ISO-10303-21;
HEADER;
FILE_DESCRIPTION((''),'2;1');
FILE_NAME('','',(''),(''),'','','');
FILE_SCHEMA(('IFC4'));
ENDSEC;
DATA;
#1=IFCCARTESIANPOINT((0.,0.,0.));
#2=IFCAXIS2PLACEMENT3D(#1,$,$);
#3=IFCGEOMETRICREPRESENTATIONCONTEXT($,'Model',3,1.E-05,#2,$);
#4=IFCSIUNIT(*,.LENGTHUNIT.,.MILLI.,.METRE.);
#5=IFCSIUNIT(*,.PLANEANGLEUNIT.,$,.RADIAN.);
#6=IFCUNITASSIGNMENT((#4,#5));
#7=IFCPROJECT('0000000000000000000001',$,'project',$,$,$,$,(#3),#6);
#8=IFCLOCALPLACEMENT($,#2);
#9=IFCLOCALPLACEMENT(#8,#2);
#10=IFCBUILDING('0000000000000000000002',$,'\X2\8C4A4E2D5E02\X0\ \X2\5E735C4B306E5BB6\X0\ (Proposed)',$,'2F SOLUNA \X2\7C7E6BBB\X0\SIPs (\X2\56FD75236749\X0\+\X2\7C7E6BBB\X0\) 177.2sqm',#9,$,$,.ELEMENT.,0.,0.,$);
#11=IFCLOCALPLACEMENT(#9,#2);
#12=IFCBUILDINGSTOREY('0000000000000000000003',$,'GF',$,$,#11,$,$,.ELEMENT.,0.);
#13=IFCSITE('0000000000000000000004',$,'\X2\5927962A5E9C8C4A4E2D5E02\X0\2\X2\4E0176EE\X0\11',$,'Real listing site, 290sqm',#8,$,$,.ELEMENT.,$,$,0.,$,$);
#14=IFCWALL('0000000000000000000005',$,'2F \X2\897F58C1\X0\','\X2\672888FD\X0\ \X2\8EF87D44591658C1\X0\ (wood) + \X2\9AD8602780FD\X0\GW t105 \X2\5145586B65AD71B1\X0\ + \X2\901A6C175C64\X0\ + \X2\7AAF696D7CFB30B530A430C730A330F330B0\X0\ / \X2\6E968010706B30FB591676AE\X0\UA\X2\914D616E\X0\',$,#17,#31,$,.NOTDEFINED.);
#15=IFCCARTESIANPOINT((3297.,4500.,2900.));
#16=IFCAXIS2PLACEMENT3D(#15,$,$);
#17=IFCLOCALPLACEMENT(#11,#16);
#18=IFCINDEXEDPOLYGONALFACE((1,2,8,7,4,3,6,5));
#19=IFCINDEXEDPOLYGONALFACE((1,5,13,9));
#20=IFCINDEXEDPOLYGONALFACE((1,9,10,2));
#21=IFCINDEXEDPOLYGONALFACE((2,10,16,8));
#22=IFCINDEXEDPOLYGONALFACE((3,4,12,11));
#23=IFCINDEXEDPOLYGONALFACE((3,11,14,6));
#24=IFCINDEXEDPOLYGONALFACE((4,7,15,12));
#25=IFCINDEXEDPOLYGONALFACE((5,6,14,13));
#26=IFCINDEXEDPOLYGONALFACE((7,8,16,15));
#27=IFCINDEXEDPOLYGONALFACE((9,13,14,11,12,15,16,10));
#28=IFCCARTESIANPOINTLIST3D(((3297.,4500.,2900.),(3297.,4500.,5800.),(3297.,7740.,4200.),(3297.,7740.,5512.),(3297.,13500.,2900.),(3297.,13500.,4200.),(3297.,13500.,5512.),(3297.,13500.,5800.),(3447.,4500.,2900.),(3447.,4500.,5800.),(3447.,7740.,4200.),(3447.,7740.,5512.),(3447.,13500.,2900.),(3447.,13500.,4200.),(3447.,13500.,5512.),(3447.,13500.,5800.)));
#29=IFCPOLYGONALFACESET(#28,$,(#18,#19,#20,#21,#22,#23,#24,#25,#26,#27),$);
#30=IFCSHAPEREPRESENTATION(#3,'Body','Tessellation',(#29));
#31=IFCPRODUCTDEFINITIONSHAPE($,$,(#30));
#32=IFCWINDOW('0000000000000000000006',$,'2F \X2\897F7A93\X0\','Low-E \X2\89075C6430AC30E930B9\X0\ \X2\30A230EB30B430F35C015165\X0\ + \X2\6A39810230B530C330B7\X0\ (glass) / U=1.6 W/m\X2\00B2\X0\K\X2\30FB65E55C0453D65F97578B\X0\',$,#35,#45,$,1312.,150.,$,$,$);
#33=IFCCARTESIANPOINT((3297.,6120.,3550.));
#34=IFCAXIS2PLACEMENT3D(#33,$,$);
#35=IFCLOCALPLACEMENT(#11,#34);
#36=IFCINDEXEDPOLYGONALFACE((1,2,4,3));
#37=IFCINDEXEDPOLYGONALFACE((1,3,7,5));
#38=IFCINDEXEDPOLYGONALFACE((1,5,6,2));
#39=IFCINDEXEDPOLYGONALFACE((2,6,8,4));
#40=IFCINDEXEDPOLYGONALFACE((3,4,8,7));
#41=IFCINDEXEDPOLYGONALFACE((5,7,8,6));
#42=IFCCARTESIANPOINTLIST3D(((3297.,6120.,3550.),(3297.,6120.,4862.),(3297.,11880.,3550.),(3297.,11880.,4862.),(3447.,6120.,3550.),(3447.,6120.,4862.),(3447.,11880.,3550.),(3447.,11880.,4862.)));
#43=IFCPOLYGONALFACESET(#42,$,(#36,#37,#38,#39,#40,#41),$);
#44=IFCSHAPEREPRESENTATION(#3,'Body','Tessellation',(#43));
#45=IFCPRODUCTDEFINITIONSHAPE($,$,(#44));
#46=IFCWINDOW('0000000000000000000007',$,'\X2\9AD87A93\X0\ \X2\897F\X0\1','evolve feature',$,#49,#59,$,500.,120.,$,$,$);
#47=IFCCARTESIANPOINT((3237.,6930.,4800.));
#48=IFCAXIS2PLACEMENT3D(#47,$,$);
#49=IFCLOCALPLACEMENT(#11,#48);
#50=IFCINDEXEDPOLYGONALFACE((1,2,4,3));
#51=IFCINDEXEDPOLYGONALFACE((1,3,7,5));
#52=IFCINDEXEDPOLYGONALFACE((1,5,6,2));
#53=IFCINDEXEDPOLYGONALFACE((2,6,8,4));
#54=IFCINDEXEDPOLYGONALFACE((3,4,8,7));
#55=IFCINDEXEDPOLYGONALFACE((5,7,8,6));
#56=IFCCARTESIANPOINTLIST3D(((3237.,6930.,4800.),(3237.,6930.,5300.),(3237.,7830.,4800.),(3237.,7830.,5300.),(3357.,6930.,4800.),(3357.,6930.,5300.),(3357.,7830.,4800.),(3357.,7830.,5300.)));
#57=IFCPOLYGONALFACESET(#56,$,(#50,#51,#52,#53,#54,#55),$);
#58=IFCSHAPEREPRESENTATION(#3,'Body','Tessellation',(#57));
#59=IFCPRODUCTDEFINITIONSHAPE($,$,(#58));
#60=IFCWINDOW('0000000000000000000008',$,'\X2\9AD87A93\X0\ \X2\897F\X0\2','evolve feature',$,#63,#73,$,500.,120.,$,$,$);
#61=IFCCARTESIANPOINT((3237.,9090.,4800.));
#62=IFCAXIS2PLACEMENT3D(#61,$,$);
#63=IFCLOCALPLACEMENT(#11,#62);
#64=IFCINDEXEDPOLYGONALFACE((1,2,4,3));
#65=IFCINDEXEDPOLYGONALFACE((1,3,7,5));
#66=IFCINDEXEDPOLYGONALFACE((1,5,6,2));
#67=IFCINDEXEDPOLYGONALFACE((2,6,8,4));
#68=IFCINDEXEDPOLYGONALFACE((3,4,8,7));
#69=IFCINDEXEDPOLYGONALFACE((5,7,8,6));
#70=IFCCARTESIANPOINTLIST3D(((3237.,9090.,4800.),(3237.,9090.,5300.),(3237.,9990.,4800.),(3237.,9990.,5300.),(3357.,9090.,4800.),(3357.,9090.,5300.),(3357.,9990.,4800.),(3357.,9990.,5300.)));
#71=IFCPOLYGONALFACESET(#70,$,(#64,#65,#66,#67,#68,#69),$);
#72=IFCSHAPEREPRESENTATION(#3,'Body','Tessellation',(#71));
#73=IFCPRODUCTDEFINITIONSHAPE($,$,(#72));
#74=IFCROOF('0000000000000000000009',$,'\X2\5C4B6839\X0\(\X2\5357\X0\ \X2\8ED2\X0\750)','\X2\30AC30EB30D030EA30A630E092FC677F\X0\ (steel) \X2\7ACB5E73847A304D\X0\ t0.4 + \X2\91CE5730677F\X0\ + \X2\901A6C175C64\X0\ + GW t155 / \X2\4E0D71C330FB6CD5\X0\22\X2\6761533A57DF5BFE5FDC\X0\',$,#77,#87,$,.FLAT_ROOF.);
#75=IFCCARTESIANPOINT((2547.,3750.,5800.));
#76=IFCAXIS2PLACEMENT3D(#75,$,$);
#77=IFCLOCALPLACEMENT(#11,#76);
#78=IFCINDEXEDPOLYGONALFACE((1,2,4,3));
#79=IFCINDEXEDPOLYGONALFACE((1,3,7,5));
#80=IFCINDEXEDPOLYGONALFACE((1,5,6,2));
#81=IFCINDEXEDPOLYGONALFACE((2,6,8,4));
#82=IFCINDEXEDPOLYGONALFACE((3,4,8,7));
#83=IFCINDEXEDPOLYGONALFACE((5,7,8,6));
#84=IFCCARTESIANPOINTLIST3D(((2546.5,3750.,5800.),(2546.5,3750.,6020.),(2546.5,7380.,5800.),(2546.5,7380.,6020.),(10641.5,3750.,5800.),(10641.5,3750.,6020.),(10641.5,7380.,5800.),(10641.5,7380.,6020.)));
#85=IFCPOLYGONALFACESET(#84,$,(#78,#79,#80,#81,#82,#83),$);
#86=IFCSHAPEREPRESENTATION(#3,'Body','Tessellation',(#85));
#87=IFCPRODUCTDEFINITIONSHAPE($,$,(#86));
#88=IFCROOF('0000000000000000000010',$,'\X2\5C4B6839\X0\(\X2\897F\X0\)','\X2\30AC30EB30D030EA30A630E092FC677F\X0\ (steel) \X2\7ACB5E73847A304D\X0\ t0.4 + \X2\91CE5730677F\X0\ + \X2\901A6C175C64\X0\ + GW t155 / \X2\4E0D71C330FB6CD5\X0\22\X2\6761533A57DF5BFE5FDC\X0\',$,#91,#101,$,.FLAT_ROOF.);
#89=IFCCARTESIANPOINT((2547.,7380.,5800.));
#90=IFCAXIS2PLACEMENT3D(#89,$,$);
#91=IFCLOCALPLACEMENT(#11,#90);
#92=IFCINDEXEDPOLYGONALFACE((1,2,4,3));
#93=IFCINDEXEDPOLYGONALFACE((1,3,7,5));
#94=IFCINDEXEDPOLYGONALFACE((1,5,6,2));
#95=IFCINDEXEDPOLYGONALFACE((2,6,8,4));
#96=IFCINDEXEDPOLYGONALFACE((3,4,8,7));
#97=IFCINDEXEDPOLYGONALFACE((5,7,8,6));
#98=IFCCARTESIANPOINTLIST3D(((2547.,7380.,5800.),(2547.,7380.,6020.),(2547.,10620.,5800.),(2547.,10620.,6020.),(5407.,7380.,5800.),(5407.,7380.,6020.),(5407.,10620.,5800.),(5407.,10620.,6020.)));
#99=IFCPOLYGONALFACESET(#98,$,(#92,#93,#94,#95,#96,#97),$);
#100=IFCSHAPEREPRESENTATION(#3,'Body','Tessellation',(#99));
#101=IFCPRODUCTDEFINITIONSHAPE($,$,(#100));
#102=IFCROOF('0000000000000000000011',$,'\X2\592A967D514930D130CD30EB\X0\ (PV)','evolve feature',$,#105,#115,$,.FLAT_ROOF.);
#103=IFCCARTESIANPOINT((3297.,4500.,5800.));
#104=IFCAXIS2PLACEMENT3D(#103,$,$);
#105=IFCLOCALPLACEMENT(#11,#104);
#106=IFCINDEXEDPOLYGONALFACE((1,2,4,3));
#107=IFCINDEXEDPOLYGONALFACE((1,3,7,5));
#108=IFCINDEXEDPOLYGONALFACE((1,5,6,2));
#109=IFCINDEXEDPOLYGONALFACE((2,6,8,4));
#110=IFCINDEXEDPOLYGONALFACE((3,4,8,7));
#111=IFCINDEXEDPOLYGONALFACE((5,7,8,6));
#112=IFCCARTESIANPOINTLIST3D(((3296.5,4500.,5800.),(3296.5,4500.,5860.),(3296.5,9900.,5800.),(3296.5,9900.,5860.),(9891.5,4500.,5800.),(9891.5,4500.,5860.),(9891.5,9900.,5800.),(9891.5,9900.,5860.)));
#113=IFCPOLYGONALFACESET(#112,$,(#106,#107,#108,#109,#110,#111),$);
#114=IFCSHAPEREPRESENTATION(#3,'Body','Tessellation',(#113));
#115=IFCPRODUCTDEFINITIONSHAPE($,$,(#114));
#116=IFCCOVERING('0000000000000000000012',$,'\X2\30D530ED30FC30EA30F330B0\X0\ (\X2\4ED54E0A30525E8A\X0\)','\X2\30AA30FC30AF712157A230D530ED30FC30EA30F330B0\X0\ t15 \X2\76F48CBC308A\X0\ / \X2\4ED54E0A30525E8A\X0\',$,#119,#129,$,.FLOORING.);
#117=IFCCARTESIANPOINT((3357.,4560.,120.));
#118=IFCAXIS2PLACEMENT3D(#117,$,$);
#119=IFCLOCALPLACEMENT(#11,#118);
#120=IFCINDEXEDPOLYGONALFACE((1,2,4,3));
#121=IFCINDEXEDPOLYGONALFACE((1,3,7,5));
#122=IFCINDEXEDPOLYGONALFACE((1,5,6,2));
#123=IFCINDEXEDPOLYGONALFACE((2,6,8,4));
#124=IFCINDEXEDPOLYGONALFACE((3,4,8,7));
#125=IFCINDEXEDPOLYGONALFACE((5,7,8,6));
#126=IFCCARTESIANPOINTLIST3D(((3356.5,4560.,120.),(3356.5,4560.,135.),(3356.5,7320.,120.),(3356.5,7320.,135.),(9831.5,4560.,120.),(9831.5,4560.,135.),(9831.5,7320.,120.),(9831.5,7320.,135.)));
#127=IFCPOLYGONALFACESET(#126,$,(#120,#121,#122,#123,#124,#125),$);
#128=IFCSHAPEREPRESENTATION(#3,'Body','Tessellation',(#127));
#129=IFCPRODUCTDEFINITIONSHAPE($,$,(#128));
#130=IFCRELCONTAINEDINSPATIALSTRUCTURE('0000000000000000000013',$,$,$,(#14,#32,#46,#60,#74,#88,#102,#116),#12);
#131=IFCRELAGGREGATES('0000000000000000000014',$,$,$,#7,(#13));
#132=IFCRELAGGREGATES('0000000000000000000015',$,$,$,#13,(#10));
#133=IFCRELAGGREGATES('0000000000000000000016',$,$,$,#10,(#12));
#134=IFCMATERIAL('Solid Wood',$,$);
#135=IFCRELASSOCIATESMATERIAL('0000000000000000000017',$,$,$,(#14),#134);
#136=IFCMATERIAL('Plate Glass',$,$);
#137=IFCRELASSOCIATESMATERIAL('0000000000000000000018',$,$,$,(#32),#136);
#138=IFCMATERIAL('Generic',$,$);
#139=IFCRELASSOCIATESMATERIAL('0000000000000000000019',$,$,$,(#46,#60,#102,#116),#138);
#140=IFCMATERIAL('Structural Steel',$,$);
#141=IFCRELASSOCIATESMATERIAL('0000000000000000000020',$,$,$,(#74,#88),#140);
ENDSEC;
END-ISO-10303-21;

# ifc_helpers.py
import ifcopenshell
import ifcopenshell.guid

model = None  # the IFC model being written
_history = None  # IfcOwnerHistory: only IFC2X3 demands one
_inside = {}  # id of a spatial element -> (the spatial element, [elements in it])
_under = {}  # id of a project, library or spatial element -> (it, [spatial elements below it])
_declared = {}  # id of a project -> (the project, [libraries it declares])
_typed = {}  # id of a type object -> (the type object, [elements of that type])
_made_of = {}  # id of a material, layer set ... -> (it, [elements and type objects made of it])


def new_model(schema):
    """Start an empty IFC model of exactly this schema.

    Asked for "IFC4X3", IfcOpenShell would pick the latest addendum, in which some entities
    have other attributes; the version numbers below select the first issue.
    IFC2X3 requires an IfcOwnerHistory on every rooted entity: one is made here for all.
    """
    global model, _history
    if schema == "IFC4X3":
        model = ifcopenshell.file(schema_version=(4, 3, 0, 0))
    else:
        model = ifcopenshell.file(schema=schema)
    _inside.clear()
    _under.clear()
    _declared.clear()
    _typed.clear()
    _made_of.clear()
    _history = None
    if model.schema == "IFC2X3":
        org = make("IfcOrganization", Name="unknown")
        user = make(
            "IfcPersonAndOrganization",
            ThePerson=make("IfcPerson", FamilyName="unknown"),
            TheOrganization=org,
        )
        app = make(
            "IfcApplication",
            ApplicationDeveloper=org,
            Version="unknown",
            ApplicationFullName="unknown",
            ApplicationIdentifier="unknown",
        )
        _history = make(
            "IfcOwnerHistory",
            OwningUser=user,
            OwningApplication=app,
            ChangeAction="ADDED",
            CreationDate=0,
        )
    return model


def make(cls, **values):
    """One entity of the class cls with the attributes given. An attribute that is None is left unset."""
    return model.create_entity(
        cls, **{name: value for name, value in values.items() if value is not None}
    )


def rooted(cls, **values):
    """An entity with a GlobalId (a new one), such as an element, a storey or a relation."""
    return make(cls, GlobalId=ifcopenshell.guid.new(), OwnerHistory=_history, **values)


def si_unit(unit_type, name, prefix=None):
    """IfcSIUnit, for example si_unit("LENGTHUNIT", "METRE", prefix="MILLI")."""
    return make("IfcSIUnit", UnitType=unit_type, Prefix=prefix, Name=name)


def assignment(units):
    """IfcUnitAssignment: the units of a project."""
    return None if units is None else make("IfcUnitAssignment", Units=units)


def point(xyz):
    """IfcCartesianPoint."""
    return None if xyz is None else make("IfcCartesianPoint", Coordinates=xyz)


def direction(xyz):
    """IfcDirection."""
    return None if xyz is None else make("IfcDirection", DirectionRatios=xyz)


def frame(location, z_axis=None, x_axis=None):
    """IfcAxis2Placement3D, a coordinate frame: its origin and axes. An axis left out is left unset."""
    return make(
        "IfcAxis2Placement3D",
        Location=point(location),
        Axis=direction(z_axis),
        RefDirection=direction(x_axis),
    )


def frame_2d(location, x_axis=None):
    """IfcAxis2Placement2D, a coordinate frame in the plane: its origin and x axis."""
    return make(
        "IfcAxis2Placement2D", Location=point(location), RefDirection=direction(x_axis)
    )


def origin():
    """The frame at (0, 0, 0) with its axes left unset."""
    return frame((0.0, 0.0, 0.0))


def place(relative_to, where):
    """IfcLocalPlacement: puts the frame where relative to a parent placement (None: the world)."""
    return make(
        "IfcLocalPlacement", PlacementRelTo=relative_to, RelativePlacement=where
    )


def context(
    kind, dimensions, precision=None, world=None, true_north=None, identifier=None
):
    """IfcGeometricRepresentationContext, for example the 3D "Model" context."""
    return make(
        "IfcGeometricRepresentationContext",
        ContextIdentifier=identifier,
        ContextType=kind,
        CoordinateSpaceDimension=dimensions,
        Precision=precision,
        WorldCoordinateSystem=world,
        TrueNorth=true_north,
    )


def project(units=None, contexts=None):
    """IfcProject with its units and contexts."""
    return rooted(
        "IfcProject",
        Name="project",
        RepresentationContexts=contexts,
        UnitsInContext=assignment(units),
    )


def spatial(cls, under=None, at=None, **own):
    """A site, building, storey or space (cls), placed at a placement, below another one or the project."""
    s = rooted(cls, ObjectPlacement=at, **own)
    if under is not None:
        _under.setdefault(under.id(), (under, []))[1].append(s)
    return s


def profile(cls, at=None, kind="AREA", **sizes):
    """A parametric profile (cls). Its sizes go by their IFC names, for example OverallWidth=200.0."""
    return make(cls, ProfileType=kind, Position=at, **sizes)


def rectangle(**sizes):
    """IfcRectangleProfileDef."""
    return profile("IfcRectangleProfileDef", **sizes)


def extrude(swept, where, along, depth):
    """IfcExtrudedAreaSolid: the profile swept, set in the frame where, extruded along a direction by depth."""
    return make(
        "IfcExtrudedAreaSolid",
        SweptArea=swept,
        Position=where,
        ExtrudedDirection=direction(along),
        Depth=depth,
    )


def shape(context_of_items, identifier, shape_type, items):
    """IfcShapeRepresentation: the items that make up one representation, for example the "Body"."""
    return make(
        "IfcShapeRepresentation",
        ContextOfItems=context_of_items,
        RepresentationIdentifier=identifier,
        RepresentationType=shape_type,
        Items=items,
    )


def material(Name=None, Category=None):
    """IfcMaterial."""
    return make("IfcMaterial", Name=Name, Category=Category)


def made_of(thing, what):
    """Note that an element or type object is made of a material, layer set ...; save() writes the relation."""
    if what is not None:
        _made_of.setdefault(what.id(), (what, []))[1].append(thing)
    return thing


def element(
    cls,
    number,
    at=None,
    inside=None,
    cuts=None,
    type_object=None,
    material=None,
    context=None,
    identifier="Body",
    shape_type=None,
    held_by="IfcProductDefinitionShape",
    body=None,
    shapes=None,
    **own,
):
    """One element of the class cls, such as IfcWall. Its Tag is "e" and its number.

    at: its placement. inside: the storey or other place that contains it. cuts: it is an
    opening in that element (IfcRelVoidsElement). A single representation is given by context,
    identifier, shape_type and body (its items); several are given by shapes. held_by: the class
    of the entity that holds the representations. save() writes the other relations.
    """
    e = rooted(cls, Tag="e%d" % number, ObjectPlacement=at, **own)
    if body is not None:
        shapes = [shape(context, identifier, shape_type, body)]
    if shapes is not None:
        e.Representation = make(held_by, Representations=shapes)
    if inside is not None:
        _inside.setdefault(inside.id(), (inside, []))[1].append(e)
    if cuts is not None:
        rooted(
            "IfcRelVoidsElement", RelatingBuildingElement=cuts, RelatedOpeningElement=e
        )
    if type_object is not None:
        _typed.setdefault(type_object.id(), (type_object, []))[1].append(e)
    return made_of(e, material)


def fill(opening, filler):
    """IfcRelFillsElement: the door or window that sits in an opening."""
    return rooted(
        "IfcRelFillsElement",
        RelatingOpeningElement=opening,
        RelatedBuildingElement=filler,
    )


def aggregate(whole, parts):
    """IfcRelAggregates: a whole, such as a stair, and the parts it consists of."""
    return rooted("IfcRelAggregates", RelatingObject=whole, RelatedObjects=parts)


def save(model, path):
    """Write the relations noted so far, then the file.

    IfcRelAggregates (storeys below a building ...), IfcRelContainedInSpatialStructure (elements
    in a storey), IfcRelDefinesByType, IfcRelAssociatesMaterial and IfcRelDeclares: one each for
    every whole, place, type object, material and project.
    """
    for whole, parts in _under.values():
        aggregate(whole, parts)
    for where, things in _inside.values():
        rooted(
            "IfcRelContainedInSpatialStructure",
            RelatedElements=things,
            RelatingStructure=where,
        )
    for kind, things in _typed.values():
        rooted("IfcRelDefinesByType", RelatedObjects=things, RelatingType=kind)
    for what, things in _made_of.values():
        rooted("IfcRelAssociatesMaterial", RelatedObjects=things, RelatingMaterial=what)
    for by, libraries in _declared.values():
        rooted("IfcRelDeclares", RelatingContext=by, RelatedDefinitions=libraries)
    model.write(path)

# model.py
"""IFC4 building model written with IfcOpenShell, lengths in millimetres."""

from ifc_helpers import new_model, si_unit, frame, frame_2d, origin, place, context, project, spatial, rectangle, extrude, material, element, fill, save


model = new_model("IFC4")

# Units and contexts
model_context = context("Model", 3, precision=1e-05, world=origin())
ifc_project = project(units=[si_unit("LENGTHUNIT", "METRE", prefix="MILLI"), si_unit("PLANEANGLEUNIT", "RADIAN")], contexts=[model_context])

# Site, building, storey
site_placement = place(None, origin())
site = spatial("IfcSite", under=ifc_project, at=site_placement, Name="大阪府豊中市2丁目11", ObjectType="Real listing site, 290sqm", CompositionType="ELEMENT", RefElevation=0.0)
building_placement = place(site_placement, origin())
building = spatial("IfcBuilding", under=site, at=building_placement, Name="豊中市 平屋の家 (Proposed)", ObjectType="2F SOLUNA 籾殻SIPs (国産杉+籾殻) 177.2sqm", CompositionType="ELEMENT", ElevationOfRefHeight=0.0, ElevationOfTerrain=0.0)
storey_placement = place(building_placement, origin())
storey = spatial("IfcBuildingStorey", under=building, at=storey_placement, Name="GF", CompositionType="ELEMENT", Elevation=0.0)

# Shared definitions
ifc_material_1 = material(Name="Solid Wood")
ifc_material_2 = material(Name="Generic")

# Shared definitions
ifc_material_3 = material(Name="Plate Glass")

# Wall, openings, windows
wall_1_placement = place(storey_placement, frame((3297.0, 4500.0, 2900.0)))
wall_1 = element("IfcWall", 1, at=wall_1_placement, inside=storey, material=ifc_material_1, Name="2F 西壁", Description="木製 軸組外壁 (wood) + 高性能GW t105 充填断熱 + 通気層 + 窯業系サイディング / 準耐火・外皮UA配慮", PredefinedType="NOTDEFINED", context=model_context, shape_type="SweptSolid", body=[
    extrude(rectangle(XDim=150.0, YDim=9000.0, at=frame_2d((75.0, 4500.0))), frame((3297.0, 4500.0, 2900.0)), (0.0, 0.0, 1.0), 2900.0),
])
opening_1_placement = place(storey_placement, frame((3297.0, 6120.0, 3550.0)))
opening_1 = element("IfcOpeningElement", 2, at=opening_1_placement, cuts=wall_1, PredefinedType="NOTDEFINED", context=model_context, shape_type="SweptSolid", body=[
    extrude(rectangle(XDim=150.0, YDim=5760.0, at=frame_2d((75.0, 2880.0))), frame((3297.0, 6120.0, 3550.0)), (0.0, 0.0, 1.0), 1312.0),
])
opening_2_placement = place(storey_placement, frame((3237.0, 6930.0, 4800.0)))
opening_2 = element("IfcOpeningElement", 3, at=opening_2_placement, cuts=wall_1, PredefinedType="NOTDEFINED", context=model_context, shape_type="SweptSolid", body=[
    extrude(rectangle(XDim=120.0, YDim=900.0, at=frame_2d((60.0, 450.0))), frame((3237.0, 6930.0, 4800.0)), (0.0, 0.0, 1.0), 500.0),
])
opening_3_placement = place(storey_placement, frame((3237.0, 9090.0, 4800.0)))
opening_3 = element("IfcOpeningElement", 4, at=opening_3_placement, cuts=wall_1, PredefinedType="NOTDEFINED", context=model_context, shape_type="SweptSolid", body=[
    extrude(rectangle(XDim=120.0, YDim=900.0, at=frame_2d((60.0, 450.0))), frame((3237.0, 9090.0, 4800.0)), (0.0, 0.0, 1.0), 500.0),
])
window_1_placement = place(storey_placement, frame((3297.0, 6120.0, 3550.0)))
window_1 = element("IfcWindow", 5, at=window_1_placement, inside=storey, material=ifc_material_3, Name="2F 西窓", Description="Low-E 複層ガラス アルゴン封入 + 樹脂サッシ (glass) / U=1.6 W/m²K・日射取得型", OverallHeight=1312.0, OverallWidth=150.0, context=model_context, shape_type="SweptSolid", body=[
    extrude(rectangle(XDim=150.0, YDim=5760.0, at=frame_2d((75.0, 2880.0))), frame((3297.0, 6120.0, 3550.0)), (0.0, 0.0, 1.0), 1312.0),
])
fill(opening_1, window_1)
window_2_placement = place(storey_placement, frame((3237.0, 6930.0, 4800.0)))
window_2 = element("IfcWindow", 6, at=window_2_placement, inside=storey, material=ifc_material_2, Name="高窓 西1", Description="evolve feature", OverallHeight=500.0, OverallWidth=120.0, context=model_context, shape_type="SweptSolid", body=[
    extrude(rectangle(XDim=120.0, YDim=900.0, at=frame_2d((60.0, 450.0))), frame((3237.0, 6930.0, 4800.0)), (0.0, 0.0, 1.0), 500.0),
])
fill(opening_2, window_2)
window_3_placement = place(storey_placement, frame((3237.0, 9090.0, 4800.0)))
window_3 = element("IfcWindow", 7, at=window_3_placement, inside=storey, material=ifc_material_2, Name="高窓 西2", Description="evolve feature", OverallHeight=500.0, OverallWidth=120.0, context=model_context, shape_type="SweptSolid", body=[
    extrude(rectangle(XDim=120.0, YDim=900.0, at=frame_2d((60.0, 450.0))), frame((3237.0, 9090.0, 4800.0)), (0.0, 0.0, 1.0), 500.0),
])
fill(opening_3, window_3)

# Roofs
ifc_material_4 = material(Name="Structural Steel")
roof_1_placement = place(storey_placement, frame((2547.0, 3750.0, 5800.0)))
element("IfcRoof", 8, at=roof_1_placement, inside=storey, material=ifc_material_4, Name="屋根(南 軒750)", Description="ガルバリウム鋼板 (steel) 立平葺き t0.4 + 野地板 + 通気層 + GW t155 / 不燃・法22条区域対応", PredefinedType="FLAT_ROOF", context=model_context, shape_type="SweptSolid", body=[
    extrude(rectangle(XDim=8095.0, YDim=3630.0, at=frame_2d((4047.0, 1815.0))), frame((2547.0, 3750.0, 5800.0)), (0.0, 0.0, 1.0), 220.0),
])
roof_2_placement = place(storey_placement, frame((2547.0, 7380.0, 5800.0)))
element("IfcRoof", 9, at=roof_2_placement, inside=storey, material=ifc_material_4, Name="屋根(西)", Description="ガルバリウム鋼板 (steel) 立平葺き t0.4 + 野地板 + 通気層 + GW t155 / 不燃・法22条区域対応", PredefinedType="FLAT_ROOF", context=model_context, shape_type="SweptSolid", body=[
    extrude(rectangle(XDim=2860.0, YDim=3240.0, at=frame_2d((1430.0, 1620.0))), frame((2547.0, 7380.0, 5800.0)), (0.0, 0.0, 1.0), 220.0),
])
roof_3_placement = place(storey_placement, frame((3297.0, 4500.0, 5800.0)))
element("IfcRoof", 10, at=roof_3_placement, inside=storey, material=ifc_material_2, Name="太陽光パネル (PV)", Description="evolve feature", PredefinedType="FLAT_ROOF", context=model_context, shape_type="SweptSolid", body=[
    extrude(rectangle(XDim=6595.0, YDim=5400.0, at=frame_2d((3297.0, 2700.0))), frame((3297.0, 4500.0, 5800.0)), (0.0, 0.0, 1.0), 60.0),
])

# Covering
covering_placement = place(storey_placement, frame((3357.0, 4560.0, 120.0)))
element("IfcCovering", 11, at=covering_placement, inside=storey, material=ifc_material_2, Name="フローリング (仕上げ床)", Description="オーク無垢フローリング t15 直貼り / 仕上げ床", PredefinedType="FLOORING", context=model_context, shape_type="SweptSolid", body=[
    extrude(rectangle(XDim=6475.0, YDim=2760.0, at=frame_2d((3237.0, 1380.0))), frame((3357.0, 4560.0, 120.0)), (0.0, 0.0, 1.0), 15.0),
])

save(model, "model.ifc")
